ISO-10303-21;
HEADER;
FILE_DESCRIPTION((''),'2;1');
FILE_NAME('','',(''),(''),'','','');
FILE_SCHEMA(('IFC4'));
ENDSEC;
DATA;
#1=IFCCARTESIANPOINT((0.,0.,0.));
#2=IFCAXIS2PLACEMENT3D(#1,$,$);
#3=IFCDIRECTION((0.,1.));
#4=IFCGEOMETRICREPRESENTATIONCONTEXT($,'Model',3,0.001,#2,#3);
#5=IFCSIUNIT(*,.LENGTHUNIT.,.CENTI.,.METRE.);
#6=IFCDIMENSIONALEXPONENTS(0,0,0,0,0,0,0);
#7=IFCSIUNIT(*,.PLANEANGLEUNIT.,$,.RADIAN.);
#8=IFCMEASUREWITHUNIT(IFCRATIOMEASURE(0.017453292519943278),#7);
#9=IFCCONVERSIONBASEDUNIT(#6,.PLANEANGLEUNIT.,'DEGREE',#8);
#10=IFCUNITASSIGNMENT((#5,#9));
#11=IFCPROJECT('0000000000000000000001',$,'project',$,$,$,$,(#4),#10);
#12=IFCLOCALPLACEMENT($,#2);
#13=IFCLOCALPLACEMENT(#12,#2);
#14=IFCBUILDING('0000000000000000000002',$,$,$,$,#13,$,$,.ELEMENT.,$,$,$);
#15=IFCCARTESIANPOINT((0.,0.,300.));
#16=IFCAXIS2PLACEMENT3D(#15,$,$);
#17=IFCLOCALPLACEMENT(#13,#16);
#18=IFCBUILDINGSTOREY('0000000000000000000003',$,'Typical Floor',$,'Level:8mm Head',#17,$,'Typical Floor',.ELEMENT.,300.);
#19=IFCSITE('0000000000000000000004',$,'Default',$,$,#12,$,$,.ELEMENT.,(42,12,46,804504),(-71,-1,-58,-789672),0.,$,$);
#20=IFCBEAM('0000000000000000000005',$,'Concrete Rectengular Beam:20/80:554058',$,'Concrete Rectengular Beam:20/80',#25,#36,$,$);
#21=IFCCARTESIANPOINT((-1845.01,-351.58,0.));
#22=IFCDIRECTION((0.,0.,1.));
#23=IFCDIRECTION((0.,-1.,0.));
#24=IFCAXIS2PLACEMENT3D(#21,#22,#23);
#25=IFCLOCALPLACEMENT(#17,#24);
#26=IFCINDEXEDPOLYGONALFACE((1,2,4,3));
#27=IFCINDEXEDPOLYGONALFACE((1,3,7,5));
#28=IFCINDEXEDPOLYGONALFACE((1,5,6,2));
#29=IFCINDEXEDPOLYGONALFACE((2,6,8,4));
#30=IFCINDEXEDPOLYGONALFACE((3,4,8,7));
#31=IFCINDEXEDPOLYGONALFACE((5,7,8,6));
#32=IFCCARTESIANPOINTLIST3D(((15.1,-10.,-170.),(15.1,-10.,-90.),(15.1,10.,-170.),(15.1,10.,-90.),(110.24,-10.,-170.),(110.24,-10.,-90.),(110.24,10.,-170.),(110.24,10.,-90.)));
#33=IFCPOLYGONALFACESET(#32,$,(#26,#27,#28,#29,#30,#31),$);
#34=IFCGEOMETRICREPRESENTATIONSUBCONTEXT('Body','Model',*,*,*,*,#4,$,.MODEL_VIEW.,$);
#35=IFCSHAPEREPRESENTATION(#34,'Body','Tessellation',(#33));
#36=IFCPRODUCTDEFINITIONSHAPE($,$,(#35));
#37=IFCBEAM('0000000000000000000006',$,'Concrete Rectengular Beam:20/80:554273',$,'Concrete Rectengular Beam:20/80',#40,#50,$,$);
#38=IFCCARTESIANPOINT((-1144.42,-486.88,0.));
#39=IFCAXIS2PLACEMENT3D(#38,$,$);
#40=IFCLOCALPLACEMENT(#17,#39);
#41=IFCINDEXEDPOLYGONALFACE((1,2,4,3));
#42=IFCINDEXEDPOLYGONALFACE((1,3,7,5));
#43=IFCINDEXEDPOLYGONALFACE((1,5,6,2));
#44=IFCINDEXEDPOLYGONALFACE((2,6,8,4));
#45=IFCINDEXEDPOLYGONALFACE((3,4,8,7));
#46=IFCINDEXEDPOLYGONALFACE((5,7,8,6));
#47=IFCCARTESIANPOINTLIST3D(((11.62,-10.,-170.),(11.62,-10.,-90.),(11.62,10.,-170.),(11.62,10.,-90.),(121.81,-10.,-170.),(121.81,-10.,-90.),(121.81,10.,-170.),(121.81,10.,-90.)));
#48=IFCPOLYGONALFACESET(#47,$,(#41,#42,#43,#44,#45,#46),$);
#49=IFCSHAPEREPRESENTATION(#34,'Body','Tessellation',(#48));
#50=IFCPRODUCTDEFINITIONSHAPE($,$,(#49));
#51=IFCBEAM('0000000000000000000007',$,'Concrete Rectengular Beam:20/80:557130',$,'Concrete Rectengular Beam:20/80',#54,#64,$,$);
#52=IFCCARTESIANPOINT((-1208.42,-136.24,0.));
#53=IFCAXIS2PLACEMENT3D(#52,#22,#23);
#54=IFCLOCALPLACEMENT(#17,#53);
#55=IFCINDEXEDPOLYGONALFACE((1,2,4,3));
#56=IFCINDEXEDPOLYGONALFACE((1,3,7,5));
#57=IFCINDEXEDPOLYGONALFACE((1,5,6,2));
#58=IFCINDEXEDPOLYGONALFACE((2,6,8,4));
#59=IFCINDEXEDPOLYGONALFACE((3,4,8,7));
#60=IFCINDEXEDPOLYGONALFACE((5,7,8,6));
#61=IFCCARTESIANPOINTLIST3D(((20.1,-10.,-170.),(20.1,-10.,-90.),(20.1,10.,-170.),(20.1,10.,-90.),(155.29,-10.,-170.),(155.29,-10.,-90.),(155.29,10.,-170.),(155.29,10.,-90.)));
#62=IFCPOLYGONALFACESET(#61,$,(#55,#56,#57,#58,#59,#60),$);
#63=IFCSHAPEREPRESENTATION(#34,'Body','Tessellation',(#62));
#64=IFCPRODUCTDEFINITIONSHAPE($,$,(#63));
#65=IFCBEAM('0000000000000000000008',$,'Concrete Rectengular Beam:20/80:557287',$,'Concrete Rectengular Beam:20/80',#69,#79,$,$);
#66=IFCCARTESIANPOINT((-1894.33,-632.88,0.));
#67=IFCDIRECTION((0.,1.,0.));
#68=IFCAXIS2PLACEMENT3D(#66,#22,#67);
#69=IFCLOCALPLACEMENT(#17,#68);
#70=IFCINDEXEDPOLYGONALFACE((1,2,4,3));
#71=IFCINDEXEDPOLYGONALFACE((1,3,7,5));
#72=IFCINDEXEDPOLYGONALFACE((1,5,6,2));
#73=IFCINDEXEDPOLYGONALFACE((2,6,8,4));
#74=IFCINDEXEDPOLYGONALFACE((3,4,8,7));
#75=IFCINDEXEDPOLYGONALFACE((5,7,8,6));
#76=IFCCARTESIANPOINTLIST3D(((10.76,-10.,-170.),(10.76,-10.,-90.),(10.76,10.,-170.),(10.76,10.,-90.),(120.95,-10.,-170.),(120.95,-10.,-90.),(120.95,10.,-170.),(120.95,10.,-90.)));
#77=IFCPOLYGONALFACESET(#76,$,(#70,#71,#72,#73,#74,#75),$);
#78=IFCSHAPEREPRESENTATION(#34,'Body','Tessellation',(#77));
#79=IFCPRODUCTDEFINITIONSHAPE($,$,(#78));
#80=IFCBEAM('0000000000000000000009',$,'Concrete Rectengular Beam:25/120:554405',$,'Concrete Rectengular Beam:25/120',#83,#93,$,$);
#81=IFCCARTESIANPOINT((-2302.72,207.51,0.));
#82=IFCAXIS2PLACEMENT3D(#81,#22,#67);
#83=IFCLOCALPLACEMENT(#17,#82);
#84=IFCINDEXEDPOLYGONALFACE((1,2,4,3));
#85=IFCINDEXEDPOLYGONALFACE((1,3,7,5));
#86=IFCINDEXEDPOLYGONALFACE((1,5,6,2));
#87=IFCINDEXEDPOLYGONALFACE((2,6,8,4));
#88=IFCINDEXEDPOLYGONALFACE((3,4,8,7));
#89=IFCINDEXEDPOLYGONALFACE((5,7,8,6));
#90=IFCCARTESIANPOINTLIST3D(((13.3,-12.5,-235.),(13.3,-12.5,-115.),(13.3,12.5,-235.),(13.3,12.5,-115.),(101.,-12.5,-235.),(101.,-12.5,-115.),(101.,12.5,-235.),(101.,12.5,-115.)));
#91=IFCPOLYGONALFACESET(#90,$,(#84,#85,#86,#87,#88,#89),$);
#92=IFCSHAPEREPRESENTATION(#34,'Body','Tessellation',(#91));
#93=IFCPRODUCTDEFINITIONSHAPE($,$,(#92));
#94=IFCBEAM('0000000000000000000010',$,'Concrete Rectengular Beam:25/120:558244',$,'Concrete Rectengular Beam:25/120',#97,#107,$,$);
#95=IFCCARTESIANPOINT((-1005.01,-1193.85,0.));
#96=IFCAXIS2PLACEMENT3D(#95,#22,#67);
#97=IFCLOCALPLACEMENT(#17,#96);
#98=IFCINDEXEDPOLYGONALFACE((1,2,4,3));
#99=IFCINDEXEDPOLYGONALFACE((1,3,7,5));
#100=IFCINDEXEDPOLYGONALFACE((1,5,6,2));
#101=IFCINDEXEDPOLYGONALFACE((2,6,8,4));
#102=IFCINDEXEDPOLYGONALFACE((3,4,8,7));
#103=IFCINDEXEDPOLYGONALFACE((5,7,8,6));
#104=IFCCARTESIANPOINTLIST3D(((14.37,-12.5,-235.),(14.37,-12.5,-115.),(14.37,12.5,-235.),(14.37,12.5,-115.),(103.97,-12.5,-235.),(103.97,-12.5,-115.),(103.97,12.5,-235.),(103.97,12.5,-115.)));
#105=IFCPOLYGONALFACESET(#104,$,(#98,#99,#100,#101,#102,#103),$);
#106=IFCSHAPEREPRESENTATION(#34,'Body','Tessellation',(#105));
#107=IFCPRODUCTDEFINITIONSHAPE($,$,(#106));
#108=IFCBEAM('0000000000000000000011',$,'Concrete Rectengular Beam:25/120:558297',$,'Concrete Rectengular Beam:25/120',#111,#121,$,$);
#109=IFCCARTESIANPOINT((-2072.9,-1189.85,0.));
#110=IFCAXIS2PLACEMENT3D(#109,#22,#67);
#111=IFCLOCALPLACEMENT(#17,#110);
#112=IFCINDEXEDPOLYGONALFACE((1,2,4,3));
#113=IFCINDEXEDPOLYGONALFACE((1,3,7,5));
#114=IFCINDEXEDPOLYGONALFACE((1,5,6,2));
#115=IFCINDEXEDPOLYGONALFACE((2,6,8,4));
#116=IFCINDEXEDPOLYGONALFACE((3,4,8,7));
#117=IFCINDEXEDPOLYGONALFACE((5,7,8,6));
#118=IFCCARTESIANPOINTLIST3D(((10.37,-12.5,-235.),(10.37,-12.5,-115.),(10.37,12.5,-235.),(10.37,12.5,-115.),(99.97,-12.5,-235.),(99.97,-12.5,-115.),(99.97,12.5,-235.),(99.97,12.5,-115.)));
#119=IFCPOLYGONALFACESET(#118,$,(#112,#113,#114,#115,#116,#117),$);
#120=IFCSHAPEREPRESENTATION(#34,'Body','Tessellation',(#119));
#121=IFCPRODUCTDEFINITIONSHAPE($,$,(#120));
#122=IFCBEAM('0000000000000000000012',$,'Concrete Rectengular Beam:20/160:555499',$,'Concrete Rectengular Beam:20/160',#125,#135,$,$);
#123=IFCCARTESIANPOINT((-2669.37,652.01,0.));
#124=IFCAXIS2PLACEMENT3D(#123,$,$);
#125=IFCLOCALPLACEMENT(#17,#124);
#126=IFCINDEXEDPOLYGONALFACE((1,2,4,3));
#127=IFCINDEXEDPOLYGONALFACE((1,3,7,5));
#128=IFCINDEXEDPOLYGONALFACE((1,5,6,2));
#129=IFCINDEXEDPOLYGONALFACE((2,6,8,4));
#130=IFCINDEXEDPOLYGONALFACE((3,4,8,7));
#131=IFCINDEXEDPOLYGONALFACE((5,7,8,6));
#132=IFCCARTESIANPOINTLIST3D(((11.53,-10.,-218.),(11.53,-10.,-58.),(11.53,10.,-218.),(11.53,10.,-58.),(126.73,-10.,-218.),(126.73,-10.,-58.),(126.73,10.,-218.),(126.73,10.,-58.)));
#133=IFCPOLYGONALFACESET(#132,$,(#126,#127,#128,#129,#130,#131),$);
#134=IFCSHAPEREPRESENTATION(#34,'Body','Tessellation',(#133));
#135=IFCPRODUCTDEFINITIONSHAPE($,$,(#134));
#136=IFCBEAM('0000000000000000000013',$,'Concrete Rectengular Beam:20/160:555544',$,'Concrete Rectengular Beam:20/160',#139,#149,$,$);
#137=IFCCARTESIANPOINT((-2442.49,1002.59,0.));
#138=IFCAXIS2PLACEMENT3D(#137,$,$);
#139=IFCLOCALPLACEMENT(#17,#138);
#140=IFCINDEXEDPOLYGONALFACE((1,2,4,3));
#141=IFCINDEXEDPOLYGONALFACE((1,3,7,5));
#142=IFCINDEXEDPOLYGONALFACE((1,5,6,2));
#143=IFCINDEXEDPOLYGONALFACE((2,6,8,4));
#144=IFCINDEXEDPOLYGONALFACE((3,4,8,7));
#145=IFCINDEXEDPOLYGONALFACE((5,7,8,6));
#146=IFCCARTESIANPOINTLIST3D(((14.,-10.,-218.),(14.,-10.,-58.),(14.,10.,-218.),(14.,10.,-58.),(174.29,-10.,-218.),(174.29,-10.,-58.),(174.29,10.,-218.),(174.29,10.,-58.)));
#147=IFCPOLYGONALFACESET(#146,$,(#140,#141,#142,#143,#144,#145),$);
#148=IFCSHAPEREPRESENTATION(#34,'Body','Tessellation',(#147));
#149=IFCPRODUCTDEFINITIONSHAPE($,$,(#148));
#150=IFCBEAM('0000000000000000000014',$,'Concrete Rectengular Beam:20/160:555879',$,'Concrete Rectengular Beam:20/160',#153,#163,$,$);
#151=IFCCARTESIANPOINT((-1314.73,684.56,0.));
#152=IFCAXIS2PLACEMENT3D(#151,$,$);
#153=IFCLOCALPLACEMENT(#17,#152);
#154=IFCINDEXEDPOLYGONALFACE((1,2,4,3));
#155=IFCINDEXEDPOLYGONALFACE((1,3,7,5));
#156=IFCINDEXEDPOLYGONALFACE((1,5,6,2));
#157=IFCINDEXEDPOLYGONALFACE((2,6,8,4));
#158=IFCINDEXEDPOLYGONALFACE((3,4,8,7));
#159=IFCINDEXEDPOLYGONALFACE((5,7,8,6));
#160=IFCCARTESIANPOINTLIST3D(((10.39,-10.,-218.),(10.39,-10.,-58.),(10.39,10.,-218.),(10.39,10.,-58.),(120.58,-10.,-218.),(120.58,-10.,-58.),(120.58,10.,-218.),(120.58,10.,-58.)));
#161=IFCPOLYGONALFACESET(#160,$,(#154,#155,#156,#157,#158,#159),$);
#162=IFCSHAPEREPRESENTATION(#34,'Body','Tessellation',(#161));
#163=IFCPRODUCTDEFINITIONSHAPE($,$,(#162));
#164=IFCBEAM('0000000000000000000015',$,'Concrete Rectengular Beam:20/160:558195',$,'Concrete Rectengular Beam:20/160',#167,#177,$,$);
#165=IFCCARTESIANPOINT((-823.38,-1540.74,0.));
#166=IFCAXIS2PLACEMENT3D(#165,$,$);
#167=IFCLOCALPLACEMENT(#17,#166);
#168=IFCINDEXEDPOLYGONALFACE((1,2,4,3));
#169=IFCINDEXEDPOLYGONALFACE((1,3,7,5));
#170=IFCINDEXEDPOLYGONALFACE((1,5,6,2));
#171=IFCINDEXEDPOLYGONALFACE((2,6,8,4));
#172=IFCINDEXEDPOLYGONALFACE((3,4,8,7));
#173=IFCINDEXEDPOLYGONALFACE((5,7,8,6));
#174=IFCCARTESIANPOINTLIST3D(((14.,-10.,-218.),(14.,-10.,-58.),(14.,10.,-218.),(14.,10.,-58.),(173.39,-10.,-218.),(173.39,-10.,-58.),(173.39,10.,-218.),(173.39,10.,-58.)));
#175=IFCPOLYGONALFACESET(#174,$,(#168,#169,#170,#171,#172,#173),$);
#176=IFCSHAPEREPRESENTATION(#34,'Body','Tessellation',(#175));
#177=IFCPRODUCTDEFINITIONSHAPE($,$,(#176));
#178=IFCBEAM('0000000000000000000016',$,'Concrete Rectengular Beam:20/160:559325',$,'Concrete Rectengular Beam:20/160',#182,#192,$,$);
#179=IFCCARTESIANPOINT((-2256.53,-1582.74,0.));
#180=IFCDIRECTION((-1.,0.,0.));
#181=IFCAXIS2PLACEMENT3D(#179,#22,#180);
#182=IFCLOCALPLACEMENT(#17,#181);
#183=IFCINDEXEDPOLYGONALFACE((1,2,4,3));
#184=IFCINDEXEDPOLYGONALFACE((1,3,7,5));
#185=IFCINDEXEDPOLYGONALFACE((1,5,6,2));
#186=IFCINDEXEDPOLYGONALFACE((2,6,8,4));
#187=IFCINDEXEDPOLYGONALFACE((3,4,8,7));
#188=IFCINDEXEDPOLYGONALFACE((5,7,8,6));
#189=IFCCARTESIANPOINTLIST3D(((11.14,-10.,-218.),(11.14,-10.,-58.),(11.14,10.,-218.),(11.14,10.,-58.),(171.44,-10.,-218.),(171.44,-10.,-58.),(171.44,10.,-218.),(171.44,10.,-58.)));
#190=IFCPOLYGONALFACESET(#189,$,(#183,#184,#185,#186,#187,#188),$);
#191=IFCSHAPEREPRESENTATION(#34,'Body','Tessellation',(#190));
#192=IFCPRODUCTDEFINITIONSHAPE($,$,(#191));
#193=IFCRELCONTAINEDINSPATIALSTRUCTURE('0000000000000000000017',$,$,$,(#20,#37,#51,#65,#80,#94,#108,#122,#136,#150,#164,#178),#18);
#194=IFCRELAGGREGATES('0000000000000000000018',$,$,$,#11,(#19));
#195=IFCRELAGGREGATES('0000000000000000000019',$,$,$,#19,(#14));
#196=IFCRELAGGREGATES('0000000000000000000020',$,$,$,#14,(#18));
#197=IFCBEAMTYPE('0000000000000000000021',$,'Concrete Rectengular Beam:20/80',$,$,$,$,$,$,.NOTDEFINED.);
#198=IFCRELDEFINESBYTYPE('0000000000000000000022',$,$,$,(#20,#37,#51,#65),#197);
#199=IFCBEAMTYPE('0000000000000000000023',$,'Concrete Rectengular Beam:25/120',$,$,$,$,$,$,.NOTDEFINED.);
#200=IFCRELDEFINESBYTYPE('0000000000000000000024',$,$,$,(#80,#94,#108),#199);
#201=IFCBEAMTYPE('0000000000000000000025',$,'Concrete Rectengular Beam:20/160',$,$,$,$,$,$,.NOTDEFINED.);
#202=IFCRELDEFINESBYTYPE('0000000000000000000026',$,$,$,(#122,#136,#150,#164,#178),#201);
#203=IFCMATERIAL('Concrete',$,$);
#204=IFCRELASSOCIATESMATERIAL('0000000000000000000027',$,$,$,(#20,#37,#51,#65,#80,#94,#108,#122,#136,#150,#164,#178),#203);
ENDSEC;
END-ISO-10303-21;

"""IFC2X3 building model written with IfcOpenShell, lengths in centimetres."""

from ifc_helpers import new_model, entity, si_unit, converted_unit, direction, frame, frame_2d, origin, origin_2d_with_axis, place, context, subcontext, project, spatial, rectangle, extrude, material, type_object, element, save


model = new_model("IFC2X3")

# Units and contexts
model_context = context("Model", 3, precision=0.001, world=origin(), true_north=direction((0.0, 1.0)))
body_context = subcontext(model_context, "Body", "Model", "MODEL_VIEW")
ifc_project = project(units=[si_unit("LENGTHUNIT", "METRE", prefix="CENTI"), converted_unit("PLANEANGLEUNIT", "DEGREE", entity("IfcRatioMeasure", 0.017453292519943278), si_unit("PLANEANGLEUNIT", "RADIAN"), dimensions=[0, 0, 0, 0, 0, 0, 0])], contexts=[model_context])

# Site, building, storey
site_placement = place(None, origin())
site = spatial("IfcSite", under=ifc_project, at=site_placement, Name="Default", CompositionType="ELEMENT", RefLatitude=(42, 12, 46, 804504), RefLongitude=(-71, -1, -58, -789672), RefElevation=0.0)
building_placement = place(site_placement, origin())
building = spatial("IfcBuilding", under=site, at=building_placement, CompositionType="ELEMENT")
storey_placement = place(building_placement, frame((0.0, 0.0, 300.0)))
storey = spatial("IfcBuildingStorey", under=building, at=storey_placement, Name="Typical Floor", ObjectType="Level:8mm Head", LongName="Typical Floor", CompositionType="ELEMENT", Elevation=300.0)

# Beams
ifc_material = material(Name="Concrete")
beam_type_1 = type_object("IfcBeamType", Name="Concrete Rectengular Beam:20/80", PredefinedType="NOTDEFINED")
beam_1_placement = place(storey_placement, frame((-1845.01, -351.58, 0.0), z_axis=(0.0, 0.0, 1.0), x_axis=(0.0, -1.0, 0.0)))
element("IfcBeam", 1, at=beam_1_placement, inside=storey, type_object=beam_type_1, material=ifc_material, Name="Concrete Rectengular Beam:20/80:554058", ObjectType="Concrete Rectengular Beam:20/80", context=body_context, shape_type="SweptSolid", body=[
    extrude(rectangle(XDim=80.0, YDim=20.0, at=frame_2d((0.0, 0.0), x_axis=(1.0, 0.0))), frame((15.1, 0.0, -130.0), z_axis=(1.0, 0.0, 0.0), x_axis=(0.0, 0.0, -1.0)), (0.0, 0.0, 1.0), 95.15),
])
beam_2_placement = place(storey_placement, frame((-1144.42, -486.88, 0.0)))
element("IfcBeam", 2, at=beam_2_placement, inside=storey, type_object=beam_type_1, material=ifc_material, Name="Concrete Rectengular Beam:20/80:554273", ObjectType="Concrete Rectengular Beam:20/80", context=body_context, shape_type="SweptSolid", body=[
    extrude(rectangle(XDim=80.0, YDim=20.0, at=frame_2d((0.0, 0.0), x_axis=(1.0, 0.0))), frame((11.62, 0.0, -130.0), z_axis=(1.0, 0.0, 0.0), x_axis=(0.0, 0.0, -1.0)), (0.0, 0.0, 1.0), 110.2),
])
beam_3_placement = place(storey_placement, frame((-1208.42, -136.24, 0.0), z_axis=(0.0, 0.0, 1.0), x_axis=(0.0, -1.0, 0.0)))
element("IfcBeam", 3, at=beam_3_placement, inside=storey, type_object=beam_type_1, material=ifc_material, Name="Concrete Rectengular Beam:20/80:557130", ObjectType="Concrete Rectengular Beam:20/80", context=body_context, shape_type="SweptSolid", body=[
    extrude(rectangle(XDim=80.0, YDim=20.0, at=frame_2d((0.0, 0.0), x_axis=(1.0, 0.0))), frame((20.1, 0.0, -130.0), z_axis=(1.0, 0.0, 0.0), x_axis=(0.0, 0.0, -1.0)), (0.0, 0.0, 1.0), 135.19),
])
beam_4_placement = place(storey_placement, frame((-1894.33, -632.88, 0.0), z_axis=(0.0, 0.0, 1.0), x_axis=(0.0, 1.0, 0.0)))
element("IfcBeam", 4, at=beam_4_placement, inside=storey, type_object=beam_type_1, material=ifc_material, Name="Concrete Rectengular Beam:20/80:557287", ObjectType="Concrete Rectengular Beam:20/80", context=body_context, shape_type="SweptSolid", body=[
    extrude(rectangle(XDim=80.0, YDim=20.0, at=frame_2d((0.0, 0.0), x_axis=(1.0, 0.0))), frame((10.76, 0.0, -130.0), z_axis=(1.0, 0.0, 0.0), x_axis=(0.0, 0.0, -1.0)), (0.0, 0.0, 1.0), 110.2),
])
beam_type_2 = type_object("IfcBeamType", Name="Concrete Rectengular Beam:25/120", PredefinedType="NOTDEFINED")
beam_5_placement = place(storey_placement, frame((-2302.72, 207.51, 0.0), z_axis=(0.0, 0.0, 1.0), x_axis=(0.0, 1.0, 0.0)))
element("IfcBeam", 5, at=beam_5_placement, inside=storey, type_object=beam_type_2, material=ifc_material, Name="Concrete Rectengular Beam:25/120:554405", ObjectType="Concrete Rectengular Beam:25/120", context=body_context, shape_type="SweptSolid", body=[
    extrude(rectangle(XDim=120.0, YDim=25.0, at=origin_2d_with_axis()), frame((13.3, 0.0, -175.0), z_axis=(1.0, 0.0, 0.0), x_axis=(0.0, 0.0, -1.0)), (0.0, 0.0, 1.0), 87.7),
])
beam_6_placement = place(storey_placement, frame((-1005.01, -1193.85, 0.0), z_axis=(0.0, 0.0, 1.0), x_axis=(0.0, 1.0, 0.0)))
element("IfcBeam", 6, at=beam_6_placement, inside=storey, type_object=beam_type_2, material=ifc_material, Name="Concrete Rectengular Beam:25/120:558244", ObjectType="Concrete Rectengular Beam:25/120", context=body_context, shape_type="SweptSolid", body=[
    extrude(rectangle(XDim=120.0, YDim=25.0, at=origin_2d_with_axis()), frame((14.37, 0.0, -175.0), z_axis=(1.0, 0.0, 0.0), x_axis=(0.0, 0.0, -1.0)), (0.0, 0.0, 1.0), 89.61),
])
beam_7_placement = place(storey_placement, frame((-2072.9, -1189.85, 0.0), z_axis=(0.0, 0.0, 1.0), x_axis=(0.0, 1.0, 0.0)))
element("IfcBeam", 7, at=beam_7_placement, inside=storey, type_object=beam_type_2, material=ifc_material, Name="Concrete Rectengular Beam:25/120:558297", ObjectType="Concrete Rectengular Beam:25/120", context=body_context, shape_type="SweptSolid", body=[
    extrude(rectangle(XDim=120.0, YDim=25.0, at=origin_2d_with_axis()), frame((10.37, 0.0, -175.0), z_axis=(1.0, 0.0, 0.0), x_axis=(0.0, 0.0, -1.0)), (0.0, 0.0, 1.0), 89.61),
])
beam_type_3 = type_object("IfcBeamType", Name="Concrete Rectengular Beam:20/160", PredefinedType="NOTDEFINED")
beam_8_placement = place(storey_placement, frame((-2669.37, 652.01, 0.0)))
element("IfcBeam", 8, at=beam_8_placement, inside=storey, type_object=beam_type_3, material=ifc_material, Name="Concrete Rectengular Beam:20/160:555499", ObjectType="Concrete Rectengular Beam:20/160", context=body_context, shape_type="SweptSolid", body=[
    extrude(rectangle(XDim=160.0, YDim=20.0, at=frame_2d((0.0, 0.0), x_axis=(1.0, 0.0))), frame((11.53, 0.0, -138.0), z_axis=(1.0, 0.0, 0.0), x_axis=(0.0, 0.0, -1.0)), (0.0, 0.0, 1.0), 115.2),
])
beam_9_placement = place(storey_placement, frame((-2442.49, 1002.59, 0.0)))
element("IfcBeam", 9, at=beam_9_placement, inside=storey, type_object=beam_type_3, material=ifc_material, Name="Concrete Rectengular Beam:20/160:555544", ObjectType="Concrete Rectengular Beam:20/160", context=body_context, shape_type="SweptSolid", body=[
    extrude(rectangle(XDim=160.0, YDim=20.0, at=frame_2d((0.0, 0.0), x_axis=(1.0, 0.0))), frame((14.0, 0.0, -138.0), z_axis=(1.0, 0.0, 0.0), x_axis=(0.0, 0.0, -1.0)), (0.0, 0.0, 1.0), 160.29),
])
beam_10_placement = place(storey_placement, frame((-1314.73, 684.56, 0.0)))
element("IfcBeam", 10, at=beam_10_placement, inside=storey, type_object=beam_type_3, material=ifc_material, Name="Concrete Rectengular Beam:20/160:555879", ObjectType="Concrete Rectengular Beam:20/160", context=body_context, shape_type="SweptSolid", body=[
    extrude(rectangle(XDim=160.0, YDim=20.0, at=frame_2d((0.0, 0.0), x_axis=(1.0, 0.0))), frame((10.39, 0.0, -138.0), z_axis=(1.0, 0.0, 0.0), x_axis=(0.0, 0.0, -1.0)), (0.0, 0.0, 1.0), 110.2),
])
beam_11_placement = place(storey_placement, frame((-823.38, -1540.74, 0.0)))
element("IfcBeam", 11, at=beam_11_placement, inside=storey, type_object=beam_type_3, material=ifc_material, Name="Concrete Rectengular Beam:20/160:558195", ObjectType="Concrete Rectengular Beam:20/160", context=body_context, shape_type="SweptSolid", body=[
    extrude(rectangle(XDim=160.0, YDim=20.0, at=frame_2d((0.0, 0.0), x_axis=(1.0, 0.0))), frame((14.0, 0.0, -138.0), z_axis=(1.0, 0.0, 0.0), x_axis=(0.0, 0.0, -1.0)), (0.0, 0.0, 1.0), 159.39),
])
beam_12_placement = place(storey_placement, frame((-2256.53, -1582.74, 0.0), z_axis=(0.0, 0.0, 1.0), x_axis=(-1.0, 0.0, 0.0)))
element("IfcBeam", 12, at=beam_12_placement, inside=storey, type_object=beam_type_3, material=ifc_material, Name="Concrete Rectengular Beam:20/160:559325", ObjectType="Concrete Rectengular Beam:20/160", context=body_context, shape_type="SweptSolid", body=[
    extrude(rectangle(XDim=160.0, YDim=20.0, at=frame_2d((0.0, 0.0), x_axis=(1.0, 0.0))), frame((11.14, 0.0, -138.0), z_axis=(1.0, 0.0, 0.0), x_axis=(0.0, 0.0, -1.0)), (0.0, 0.0, 1.0), 160.29),
])

save(model, "model.ifc")
